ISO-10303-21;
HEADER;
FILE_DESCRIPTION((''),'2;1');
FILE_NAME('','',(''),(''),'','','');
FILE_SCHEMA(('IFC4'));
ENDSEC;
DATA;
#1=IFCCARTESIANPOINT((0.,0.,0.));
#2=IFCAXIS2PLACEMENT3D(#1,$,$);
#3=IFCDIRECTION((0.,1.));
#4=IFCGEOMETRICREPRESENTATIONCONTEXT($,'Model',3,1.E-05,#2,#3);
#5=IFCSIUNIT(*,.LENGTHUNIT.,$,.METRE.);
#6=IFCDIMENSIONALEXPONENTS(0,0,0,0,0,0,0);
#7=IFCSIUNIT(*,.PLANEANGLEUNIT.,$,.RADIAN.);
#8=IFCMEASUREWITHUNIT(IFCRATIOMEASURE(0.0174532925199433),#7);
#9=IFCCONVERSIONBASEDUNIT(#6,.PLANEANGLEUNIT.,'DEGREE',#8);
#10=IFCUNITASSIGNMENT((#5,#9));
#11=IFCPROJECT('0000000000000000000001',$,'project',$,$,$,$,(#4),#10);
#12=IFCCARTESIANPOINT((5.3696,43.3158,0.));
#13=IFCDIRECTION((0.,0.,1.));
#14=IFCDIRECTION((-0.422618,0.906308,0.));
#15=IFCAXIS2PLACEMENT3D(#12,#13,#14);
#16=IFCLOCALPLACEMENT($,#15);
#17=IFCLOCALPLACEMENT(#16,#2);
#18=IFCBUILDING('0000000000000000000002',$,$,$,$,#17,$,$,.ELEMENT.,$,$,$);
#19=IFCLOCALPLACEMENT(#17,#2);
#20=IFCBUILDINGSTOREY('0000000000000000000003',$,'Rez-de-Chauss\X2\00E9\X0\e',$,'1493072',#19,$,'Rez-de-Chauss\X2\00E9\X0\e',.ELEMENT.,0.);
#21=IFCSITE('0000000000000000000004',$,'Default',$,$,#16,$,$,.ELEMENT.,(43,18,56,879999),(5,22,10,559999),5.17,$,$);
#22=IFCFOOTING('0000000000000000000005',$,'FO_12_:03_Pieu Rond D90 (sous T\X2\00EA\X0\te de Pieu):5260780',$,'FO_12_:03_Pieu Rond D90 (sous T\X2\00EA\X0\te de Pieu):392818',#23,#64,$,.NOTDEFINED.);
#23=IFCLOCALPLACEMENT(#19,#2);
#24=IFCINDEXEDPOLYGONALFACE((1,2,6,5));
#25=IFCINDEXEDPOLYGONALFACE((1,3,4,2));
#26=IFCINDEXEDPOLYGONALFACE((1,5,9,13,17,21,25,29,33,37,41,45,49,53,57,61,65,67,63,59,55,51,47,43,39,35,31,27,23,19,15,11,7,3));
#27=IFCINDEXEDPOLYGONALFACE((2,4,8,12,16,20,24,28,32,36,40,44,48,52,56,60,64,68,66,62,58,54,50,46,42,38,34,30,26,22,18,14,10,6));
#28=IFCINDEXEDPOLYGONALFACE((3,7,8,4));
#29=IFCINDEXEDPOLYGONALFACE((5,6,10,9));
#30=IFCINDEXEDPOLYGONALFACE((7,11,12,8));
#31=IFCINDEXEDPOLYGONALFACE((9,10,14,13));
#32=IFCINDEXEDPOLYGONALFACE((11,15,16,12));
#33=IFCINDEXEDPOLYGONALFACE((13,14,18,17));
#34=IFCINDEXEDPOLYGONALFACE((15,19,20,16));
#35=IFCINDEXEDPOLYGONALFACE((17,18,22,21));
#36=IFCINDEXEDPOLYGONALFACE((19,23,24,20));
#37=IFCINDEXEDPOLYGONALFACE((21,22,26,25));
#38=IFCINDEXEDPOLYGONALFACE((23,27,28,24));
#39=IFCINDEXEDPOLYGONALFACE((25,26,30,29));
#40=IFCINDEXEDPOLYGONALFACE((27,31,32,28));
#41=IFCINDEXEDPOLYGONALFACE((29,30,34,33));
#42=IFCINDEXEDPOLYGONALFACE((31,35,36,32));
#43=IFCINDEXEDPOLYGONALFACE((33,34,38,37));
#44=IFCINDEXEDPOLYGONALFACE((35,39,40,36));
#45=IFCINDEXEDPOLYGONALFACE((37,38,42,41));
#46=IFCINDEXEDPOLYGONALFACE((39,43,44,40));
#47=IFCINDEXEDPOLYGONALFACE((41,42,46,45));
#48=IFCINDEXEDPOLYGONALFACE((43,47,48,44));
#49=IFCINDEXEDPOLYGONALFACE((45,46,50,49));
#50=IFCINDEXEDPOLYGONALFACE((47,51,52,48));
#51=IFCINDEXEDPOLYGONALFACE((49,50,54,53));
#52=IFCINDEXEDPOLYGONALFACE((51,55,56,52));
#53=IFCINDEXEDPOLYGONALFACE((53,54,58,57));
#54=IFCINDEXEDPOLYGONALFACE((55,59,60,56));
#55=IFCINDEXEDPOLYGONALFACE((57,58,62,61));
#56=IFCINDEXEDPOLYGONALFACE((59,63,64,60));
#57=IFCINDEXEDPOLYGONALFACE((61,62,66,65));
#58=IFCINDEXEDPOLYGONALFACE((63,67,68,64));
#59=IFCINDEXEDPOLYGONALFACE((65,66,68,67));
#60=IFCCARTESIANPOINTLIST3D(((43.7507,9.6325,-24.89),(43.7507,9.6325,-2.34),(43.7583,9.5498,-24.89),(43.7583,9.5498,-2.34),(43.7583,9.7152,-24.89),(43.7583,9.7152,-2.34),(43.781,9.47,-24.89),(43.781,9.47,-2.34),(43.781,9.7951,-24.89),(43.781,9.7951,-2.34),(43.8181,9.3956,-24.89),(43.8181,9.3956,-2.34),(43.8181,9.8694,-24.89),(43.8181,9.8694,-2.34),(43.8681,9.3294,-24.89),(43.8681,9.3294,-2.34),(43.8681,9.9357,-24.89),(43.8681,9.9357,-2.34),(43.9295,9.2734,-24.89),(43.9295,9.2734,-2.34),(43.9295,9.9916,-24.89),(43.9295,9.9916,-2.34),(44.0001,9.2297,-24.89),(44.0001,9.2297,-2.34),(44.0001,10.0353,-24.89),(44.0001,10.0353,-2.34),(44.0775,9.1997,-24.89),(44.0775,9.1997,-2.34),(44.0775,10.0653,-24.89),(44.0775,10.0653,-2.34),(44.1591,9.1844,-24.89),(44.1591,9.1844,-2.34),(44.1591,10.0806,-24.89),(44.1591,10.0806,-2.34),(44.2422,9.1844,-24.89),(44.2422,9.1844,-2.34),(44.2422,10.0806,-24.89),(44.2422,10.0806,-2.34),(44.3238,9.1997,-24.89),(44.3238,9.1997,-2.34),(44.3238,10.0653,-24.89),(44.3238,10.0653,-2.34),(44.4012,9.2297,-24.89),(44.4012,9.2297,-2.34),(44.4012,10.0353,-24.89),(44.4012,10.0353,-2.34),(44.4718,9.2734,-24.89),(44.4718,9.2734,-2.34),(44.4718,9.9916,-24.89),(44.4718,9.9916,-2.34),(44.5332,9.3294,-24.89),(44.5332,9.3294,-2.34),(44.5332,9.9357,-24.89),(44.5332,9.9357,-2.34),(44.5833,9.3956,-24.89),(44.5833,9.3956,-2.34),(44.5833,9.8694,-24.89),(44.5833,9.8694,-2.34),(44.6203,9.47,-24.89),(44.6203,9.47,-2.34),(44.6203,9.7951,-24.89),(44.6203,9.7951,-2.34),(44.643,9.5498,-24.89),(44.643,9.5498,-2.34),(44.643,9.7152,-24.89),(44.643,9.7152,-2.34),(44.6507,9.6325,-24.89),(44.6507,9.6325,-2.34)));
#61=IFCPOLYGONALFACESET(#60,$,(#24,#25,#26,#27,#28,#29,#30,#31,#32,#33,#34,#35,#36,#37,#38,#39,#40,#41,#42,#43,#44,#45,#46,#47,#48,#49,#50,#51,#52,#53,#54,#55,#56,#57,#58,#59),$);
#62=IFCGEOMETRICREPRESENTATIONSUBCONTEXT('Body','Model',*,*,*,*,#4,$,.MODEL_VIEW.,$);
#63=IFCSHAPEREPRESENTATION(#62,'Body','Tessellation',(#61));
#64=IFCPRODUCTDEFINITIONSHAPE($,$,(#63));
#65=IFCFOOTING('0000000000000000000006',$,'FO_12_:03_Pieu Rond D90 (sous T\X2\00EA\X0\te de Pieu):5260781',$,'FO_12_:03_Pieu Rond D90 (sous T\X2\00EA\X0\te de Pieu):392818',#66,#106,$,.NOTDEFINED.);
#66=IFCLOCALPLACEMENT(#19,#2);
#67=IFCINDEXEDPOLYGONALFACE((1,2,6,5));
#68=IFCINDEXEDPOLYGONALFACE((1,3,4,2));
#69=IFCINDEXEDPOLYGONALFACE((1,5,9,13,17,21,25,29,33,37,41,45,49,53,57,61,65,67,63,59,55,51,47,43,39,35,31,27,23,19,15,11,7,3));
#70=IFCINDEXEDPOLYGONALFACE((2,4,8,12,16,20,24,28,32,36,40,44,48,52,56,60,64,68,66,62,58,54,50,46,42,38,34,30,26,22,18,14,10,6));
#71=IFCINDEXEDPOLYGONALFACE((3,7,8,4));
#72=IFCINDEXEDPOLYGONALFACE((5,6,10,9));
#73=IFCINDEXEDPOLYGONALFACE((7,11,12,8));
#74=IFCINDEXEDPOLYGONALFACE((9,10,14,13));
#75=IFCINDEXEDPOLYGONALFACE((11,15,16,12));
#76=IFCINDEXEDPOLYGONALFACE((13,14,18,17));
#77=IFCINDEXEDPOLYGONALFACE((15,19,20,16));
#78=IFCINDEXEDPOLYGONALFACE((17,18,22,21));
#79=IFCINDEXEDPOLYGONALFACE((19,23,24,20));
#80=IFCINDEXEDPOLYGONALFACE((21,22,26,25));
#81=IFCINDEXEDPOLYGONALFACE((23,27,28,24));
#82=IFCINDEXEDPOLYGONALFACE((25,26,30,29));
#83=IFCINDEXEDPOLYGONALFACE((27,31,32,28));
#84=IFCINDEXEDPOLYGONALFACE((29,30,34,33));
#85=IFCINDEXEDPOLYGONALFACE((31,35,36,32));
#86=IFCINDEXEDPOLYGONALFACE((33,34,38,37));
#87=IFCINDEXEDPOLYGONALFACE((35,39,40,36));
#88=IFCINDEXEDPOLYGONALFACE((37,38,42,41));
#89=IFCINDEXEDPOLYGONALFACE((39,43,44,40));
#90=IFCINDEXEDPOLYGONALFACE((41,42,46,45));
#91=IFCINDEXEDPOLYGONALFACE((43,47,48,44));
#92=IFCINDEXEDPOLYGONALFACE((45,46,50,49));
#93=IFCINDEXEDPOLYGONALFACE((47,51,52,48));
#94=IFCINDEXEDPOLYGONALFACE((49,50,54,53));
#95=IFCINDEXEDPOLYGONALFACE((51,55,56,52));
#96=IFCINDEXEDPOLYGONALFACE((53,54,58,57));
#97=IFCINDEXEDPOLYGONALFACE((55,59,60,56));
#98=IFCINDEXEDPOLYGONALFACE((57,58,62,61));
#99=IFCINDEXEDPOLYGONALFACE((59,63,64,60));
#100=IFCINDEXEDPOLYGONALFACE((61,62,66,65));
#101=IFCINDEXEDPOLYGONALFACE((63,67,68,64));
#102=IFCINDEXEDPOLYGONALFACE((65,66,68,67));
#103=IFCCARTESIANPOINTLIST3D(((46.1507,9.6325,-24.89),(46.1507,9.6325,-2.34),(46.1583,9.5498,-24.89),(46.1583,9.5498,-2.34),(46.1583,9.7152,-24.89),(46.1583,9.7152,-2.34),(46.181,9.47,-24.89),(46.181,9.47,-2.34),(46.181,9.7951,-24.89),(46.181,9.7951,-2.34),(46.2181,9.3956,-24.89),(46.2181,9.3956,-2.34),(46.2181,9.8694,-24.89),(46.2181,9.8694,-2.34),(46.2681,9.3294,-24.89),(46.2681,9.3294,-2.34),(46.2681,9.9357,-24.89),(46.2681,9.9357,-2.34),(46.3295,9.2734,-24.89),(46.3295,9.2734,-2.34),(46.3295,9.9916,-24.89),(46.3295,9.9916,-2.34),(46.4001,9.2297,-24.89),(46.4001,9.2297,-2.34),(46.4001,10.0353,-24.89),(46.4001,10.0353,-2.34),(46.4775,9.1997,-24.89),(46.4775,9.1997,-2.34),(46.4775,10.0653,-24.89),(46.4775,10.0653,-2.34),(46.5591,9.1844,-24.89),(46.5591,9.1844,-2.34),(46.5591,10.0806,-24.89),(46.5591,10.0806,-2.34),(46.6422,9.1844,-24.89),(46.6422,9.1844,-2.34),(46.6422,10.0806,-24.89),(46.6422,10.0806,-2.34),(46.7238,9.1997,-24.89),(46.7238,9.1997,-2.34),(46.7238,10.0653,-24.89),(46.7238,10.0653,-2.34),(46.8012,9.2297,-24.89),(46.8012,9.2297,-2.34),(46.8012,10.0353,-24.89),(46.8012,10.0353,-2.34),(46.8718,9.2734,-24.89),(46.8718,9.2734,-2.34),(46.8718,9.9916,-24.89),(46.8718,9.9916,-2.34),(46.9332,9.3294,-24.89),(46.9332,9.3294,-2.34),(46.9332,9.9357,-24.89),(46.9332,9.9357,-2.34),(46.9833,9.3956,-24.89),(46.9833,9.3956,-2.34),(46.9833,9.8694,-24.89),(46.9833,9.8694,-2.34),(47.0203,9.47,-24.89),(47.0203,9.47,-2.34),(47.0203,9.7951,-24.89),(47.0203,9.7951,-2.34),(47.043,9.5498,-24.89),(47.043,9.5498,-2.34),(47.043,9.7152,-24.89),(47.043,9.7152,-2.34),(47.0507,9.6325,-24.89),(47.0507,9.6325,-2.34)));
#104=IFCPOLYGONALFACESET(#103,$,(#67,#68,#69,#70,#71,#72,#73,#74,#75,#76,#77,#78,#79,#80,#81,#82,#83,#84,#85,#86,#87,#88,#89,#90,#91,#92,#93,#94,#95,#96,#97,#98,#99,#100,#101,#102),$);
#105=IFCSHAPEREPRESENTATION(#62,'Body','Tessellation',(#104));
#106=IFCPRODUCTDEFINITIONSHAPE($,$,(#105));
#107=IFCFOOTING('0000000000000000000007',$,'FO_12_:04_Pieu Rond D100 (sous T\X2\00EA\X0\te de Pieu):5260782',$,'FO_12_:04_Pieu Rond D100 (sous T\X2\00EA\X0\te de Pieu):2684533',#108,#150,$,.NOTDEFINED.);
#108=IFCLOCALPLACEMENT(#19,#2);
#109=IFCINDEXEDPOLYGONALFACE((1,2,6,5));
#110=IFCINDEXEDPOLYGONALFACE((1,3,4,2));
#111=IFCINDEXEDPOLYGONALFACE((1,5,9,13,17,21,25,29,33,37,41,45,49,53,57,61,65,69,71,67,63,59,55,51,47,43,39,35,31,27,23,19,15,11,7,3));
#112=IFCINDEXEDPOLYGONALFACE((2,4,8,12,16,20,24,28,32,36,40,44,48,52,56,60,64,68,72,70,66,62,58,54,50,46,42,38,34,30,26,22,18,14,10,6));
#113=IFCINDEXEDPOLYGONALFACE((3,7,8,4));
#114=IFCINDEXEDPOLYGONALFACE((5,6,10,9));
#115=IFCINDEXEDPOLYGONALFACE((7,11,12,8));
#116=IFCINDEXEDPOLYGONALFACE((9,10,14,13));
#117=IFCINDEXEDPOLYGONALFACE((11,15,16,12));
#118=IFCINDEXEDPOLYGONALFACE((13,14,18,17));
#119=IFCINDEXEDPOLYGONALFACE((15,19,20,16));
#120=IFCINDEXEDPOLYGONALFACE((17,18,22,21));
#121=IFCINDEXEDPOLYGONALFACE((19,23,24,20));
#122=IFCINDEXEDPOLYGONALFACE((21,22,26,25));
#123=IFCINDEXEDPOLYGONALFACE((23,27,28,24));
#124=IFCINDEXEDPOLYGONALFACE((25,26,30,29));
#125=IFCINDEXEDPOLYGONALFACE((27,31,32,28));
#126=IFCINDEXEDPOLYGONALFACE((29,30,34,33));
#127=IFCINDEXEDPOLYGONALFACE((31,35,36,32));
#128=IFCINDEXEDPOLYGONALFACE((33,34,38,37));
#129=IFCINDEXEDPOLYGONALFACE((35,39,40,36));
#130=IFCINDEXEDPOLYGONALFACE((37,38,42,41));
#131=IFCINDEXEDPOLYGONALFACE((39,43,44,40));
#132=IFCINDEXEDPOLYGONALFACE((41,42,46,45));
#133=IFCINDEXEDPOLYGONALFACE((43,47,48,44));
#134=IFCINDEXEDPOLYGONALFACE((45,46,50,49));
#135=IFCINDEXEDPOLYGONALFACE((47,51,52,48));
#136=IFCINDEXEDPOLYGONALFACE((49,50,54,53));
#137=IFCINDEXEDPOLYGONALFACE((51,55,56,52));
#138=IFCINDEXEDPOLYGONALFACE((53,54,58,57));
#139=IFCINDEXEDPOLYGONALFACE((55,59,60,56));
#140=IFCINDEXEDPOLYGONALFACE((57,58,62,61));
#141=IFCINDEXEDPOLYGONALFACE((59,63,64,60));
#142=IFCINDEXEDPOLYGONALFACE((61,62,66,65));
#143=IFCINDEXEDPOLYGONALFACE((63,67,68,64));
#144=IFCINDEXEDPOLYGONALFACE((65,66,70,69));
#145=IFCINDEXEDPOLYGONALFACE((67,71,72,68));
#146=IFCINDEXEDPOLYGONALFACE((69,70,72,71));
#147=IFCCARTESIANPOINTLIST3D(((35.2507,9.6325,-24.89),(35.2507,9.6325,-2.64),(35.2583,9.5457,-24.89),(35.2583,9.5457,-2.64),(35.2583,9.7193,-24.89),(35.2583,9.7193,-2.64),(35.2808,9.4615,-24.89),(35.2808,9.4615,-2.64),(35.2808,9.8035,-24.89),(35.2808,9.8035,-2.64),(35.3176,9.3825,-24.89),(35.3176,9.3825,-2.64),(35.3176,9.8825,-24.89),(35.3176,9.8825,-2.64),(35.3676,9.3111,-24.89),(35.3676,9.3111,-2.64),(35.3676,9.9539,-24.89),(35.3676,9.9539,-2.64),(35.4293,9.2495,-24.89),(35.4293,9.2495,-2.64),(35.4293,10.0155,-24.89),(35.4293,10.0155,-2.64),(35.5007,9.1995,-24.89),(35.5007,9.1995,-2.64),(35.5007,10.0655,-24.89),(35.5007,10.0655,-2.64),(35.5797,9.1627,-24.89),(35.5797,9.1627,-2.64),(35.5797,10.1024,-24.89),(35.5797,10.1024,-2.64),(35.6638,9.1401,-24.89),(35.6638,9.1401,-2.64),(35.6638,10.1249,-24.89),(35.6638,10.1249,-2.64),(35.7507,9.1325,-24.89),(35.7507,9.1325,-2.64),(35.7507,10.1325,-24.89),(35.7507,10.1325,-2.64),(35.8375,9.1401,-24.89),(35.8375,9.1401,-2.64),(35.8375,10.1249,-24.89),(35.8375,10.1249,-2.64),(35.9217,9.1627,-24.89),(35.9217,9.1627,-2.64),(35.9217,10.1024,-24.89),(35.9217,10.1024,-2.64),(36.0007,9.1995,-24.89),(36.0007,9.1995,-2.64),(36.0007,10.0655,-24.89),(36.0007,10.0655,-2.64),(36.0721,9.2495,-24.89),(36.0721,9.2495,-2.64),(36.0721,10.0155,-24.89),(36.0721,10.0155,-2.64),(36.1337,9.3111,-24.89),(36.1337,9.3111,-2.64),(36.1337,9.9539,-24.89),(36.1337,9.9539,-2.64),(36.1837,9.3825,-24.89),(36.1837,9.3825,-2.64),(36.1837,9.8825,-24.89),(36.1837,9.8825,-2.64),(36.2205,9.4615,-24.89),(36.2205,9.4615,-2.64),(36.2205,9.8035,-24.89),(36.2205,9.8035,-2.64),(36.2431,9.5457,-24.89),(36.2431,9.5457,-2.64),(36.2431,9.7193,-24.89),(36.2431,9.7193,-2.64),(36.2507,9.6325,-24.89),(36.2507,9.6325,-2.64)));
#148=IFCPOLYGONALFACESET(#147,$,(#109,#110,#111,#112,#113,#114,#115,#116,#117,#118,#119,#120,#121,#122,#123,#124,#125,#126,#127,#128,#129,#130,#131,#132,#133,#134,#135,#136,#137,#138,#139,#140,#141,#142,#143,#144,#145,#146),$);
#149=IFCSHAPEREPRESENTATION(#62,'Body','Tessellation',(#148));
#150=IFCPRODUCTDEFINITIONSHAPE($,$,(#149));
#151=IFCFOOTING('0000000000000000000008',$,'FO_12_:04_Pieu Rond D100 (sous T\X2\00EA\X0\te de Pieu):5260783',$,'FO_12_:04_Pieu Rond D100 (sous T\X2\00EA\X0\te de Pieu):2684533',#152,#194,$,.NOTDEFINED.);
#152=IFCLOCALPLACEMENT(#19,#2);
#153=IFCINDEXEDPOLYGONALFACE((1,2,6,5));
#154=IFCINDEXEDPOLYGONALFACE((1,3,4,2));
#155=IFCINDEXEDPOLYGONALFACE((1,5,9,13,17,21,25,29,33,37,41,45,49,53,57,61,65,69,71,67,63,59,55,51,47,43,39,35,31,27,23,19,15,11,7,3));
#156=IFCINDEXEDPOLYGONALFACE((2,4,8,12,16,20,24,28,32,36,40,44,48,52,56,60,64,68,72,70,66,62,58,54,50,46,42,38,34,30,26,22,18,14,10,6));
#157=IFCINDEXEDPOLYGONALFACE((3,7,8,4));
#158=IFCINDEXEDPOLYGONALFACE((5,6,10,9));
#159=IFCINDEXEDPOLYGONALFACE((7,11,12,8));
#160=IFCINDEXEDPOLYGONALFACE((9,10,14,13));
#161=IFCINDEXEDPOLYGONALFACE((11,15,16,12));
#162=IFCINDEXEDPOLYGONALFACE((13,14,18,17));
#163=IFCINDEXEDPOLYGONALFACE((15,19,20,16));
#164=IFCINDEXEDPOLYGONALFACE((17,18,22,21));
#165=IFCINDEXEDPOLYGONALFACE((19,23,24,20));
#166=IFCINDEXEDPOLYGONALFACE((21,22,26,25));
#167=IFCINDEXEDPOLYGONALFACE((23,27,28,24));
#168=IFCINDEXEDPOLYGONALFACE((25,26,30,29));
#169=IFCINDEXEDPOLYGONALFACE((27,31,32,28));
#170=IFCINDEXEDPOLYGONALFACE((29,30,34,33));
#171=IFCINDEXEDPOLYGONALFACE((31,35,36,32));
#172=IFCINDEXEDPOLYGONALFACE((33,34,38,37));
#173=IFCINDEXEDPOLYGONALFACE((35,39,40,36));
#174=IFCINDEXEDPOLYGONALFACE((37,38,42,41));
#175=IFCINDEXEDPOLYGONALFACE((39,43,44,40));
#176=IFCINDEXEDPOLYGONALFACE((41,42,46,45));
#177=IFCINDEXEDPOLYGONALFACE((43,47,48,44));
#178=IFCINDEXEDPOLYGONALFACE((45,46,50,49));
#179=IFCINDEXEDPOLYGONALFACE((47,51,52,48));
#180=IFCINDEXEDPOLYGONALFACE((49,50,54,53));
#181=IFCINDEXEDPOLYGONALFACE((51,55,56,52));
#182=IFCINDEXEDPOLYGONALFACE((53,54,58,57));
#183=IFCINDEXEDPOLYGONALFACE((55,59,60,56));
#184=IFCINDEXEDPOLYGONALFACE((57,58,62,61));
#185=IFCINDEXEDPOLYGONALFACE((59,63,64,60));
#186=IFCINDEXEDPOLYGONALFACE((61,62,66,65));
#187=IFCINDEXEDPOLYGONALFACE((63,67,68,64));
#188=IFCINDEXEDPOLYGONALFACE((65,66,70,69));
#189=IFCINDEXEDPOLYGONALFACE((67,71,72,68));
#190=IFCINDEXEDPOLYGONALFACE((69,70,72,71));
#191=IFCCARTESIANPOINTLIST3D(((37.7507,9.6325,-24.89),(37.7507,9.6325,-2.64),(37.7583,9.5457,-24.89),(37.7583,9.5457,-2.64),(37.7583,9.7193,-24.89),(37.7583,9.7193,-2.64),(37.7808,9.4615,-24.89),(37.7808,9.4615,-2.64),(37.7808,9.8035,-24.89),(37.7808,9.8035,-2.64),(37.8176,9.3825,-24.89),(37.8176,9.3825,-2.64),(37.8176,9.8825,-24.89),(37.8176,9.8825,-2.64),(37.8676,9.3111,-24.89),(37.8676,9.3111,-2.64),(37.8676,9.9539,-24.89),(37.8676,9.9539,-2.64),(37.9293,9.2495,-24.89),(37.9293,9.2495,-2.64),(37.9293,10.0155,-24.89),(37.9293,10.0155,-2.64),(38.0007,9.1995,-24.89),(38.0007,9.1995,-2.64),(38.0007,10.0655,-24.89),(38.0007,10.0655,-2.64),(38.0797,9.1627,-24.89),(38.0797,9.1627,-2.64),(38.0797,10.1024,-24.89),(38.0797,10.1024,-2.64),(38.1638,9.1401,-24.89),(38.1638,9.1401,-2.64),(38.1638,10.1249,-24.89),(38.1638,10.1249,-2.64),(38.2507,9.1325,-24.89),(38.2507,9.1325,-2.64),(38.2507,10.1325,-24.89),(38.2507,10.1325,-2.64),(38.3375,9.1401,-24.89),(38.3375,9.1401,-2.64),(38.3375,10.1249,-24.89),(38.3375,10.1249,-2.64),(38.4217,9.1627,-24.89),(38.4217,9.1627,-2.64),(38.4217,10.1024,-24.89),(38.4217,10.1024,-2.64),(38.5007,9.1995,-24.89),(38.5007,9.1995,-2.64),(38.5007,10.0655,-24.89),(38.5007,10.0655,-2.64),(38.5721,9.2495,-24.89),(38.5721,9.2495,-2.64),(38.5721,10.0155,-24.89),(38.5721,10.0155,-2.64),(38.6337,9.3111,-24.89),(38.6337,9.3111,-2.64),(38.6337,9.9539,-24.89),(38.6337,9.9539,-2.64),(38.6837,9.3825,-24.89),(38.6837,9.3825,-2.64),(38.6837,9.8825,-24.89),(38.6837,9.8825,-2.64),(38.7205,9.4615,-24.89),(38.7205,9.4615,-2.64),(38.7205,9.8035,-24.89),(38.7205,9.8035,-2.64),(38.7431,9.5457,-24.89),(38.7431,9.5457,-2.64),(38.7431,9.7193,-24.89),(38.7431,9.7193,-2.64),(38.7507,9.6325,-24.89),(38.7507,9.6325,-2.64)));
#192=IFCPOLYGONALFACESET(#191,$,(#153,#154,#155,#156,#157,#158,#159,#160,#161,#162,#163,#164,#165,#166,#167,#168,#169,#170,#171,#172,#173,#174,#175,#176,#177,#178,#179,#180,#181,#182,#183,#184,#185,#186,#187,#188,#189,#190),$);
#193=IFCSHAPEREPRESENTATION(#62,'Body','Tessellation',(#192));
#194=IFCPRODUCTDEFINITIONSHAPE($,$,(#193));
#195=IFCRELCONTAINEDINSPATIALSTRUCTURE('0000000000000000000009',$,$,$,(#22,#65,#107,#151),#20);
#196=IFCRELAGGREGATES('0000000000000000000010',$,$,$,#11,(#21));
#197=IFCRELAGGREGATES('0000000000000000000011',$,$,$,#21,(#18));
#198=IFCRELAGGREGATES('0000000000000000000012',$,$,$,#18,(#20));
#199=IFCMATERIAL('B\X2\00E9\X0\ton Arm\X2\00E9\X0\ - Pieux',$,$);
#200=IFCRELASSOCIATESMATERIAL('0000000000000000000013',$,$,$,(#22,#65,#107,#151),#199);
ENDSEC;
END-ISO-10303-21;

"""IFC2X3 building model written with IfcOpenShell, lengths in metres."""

from ifc_helpers import new_model, entity, si_unit, converted_unit, direction, frame, frame_2d, origin, place, context, subcontext, project, spatial, circle, extrude, material, element, save


model = new_model("IFC2X3")

# Units and contexts
model_context = context("Model", 3, precision=1e-05, world=origin(), true_north=direction((0.0, 1.0)))
body_context = subcontext(model_context, "Body", "Model", "MODEL_VIEW")
ifc_project = project(units=[si_unit("LENGTHUNIT", "METRE"), converted_unit("PLANEANGLEUNIT", "DEGREE", entity("IfcRatioMeasure", 0.0174532925199433), si_unit("PLANEANGLEUNIT", "RADIAN"), dimensions=[0, 0, 0, 0, 0, 0, 0])], contexts=[model_context])

# Site, building, storey
site_placement = place(None, frame((5.3696, 43.3158, 0.0), z_axis=(0.0, 0.0, 1.0), x_axis=(-0.422618, 0.906308, 0.0)))
site = spatial("IfcSite", under=ifc_project, at=site_placement, Name="Default", CompositionType="ELEMENT", RefLatitude=(43, 18, 56, 879999), RefLongitude=(5, 22, 10, 559999), RefElevation=5.17)
building_placement = place(site_placement, origin())
building = spatial("IfcBuilding", under=site, at=building_placement, CompositionType="ELEMENT")
storey_placement = place(building_placement, origin())
storey = spatial("IfcBuildingStorey", under=building, at=storey_placement, Name="Rez-de-Chaussée", ObjectType="1493072", LongName="Rez-de-Chaussée", CompositionType="ELEMENT", Elevation=0.0)

# Footings
ifc_material_1 = material(Name="Béton Armé - Pieux")
footing_1_placement = place(storey_placement, origin())
element("IfcFooting", 1, at=footing_1_placement, inside=storey, material=ifc_material_1, Name="FO_12_:03_Pieu Rond D90 (sous Tête de Pieu):5260780", ObjectType="FO_12_:03_Pieu Rond D90 (sous Tête de Pieu):392818", PredefinedType="NOTDEFINED", context=body_context, shape_type="SweptSolid", body=[
    extrude(circle(Radius=0.45, at=frame_2d((0.0, 0.0), x_axis=(1.0, 0.0))), frame((44.2007, 9.6325, -24.89)), (0.0, 0.0, 1.0), 22.55),
])
footing_2_placement = place(storey_placement, origin())
element("IfcFooting", 2, at=footing_2_placement, inside=storey, material=ifc_material_1, Name="FO_12_:03_Pieu Rond D90 (sous Tête de Pieu):5260781", ObjectType="FO_12_:03_Pieu Rond D90 (sous Tête de Pieu):392818", PredefinedType="NOTDEFINED", context=body_context, shape_type="SweptSolid", body=[
    extrude(circle(Radius=0.45, at=frame_2d((0.0, 0.0), x_axis=(1.0, 0.0))), frame((46.6007, 9.6325, -24.89)), (0.0, 0.0, 1.0), 22.55),
])
footing_3_placement = place(storey_placement, origin())
element("IfcFooting", 3, at=footing_3_placement, inside=storey, material=ifc_material_1, Name="FO_12_:04_Pieu Rond D100 (sous Tête de Pieu):5260782", ObjectType="FO_12_:04_Pieu Rond D100 (sous Tête de Pieu):2684533", PredefinedType="NOTDEFINED", context=body_context, shape_type="SweptSolid", body=[
    extrude(circle(Radius=0.5, at=frame_2d((0.0, 0.0), x_axis=(1.0, 0.0))), frame((35.7507, 9.6325, -24.89)), (0.0, 0.0, 1.0), 22.25),
])
footing_4_placement = place(storey_placement, origin())
element("IfcFooting", 4, at=footing_4_placement, inside=storey, material=ifc_material_1, Name="FO_12_:04_Pieu Rond D100 (sous Tête de Pieu):5260783", ObjectType="FO_12_:04_Pieu Rond D100 (sous Tête de Pieu):2684533", PredefinedType="NOTDEFINED", context=body_context, shape_type="SweptSolid", body=[
    extrude(circle(Radius=0.5, at=frame_2d((0.0, 0.0), x_axis=(1.0, 0.0))), frame((38.2507, 9.6325, -24.89)), (0.0, 0.0, 1.0), 22.25),
])

save(model, "model.ifc")
